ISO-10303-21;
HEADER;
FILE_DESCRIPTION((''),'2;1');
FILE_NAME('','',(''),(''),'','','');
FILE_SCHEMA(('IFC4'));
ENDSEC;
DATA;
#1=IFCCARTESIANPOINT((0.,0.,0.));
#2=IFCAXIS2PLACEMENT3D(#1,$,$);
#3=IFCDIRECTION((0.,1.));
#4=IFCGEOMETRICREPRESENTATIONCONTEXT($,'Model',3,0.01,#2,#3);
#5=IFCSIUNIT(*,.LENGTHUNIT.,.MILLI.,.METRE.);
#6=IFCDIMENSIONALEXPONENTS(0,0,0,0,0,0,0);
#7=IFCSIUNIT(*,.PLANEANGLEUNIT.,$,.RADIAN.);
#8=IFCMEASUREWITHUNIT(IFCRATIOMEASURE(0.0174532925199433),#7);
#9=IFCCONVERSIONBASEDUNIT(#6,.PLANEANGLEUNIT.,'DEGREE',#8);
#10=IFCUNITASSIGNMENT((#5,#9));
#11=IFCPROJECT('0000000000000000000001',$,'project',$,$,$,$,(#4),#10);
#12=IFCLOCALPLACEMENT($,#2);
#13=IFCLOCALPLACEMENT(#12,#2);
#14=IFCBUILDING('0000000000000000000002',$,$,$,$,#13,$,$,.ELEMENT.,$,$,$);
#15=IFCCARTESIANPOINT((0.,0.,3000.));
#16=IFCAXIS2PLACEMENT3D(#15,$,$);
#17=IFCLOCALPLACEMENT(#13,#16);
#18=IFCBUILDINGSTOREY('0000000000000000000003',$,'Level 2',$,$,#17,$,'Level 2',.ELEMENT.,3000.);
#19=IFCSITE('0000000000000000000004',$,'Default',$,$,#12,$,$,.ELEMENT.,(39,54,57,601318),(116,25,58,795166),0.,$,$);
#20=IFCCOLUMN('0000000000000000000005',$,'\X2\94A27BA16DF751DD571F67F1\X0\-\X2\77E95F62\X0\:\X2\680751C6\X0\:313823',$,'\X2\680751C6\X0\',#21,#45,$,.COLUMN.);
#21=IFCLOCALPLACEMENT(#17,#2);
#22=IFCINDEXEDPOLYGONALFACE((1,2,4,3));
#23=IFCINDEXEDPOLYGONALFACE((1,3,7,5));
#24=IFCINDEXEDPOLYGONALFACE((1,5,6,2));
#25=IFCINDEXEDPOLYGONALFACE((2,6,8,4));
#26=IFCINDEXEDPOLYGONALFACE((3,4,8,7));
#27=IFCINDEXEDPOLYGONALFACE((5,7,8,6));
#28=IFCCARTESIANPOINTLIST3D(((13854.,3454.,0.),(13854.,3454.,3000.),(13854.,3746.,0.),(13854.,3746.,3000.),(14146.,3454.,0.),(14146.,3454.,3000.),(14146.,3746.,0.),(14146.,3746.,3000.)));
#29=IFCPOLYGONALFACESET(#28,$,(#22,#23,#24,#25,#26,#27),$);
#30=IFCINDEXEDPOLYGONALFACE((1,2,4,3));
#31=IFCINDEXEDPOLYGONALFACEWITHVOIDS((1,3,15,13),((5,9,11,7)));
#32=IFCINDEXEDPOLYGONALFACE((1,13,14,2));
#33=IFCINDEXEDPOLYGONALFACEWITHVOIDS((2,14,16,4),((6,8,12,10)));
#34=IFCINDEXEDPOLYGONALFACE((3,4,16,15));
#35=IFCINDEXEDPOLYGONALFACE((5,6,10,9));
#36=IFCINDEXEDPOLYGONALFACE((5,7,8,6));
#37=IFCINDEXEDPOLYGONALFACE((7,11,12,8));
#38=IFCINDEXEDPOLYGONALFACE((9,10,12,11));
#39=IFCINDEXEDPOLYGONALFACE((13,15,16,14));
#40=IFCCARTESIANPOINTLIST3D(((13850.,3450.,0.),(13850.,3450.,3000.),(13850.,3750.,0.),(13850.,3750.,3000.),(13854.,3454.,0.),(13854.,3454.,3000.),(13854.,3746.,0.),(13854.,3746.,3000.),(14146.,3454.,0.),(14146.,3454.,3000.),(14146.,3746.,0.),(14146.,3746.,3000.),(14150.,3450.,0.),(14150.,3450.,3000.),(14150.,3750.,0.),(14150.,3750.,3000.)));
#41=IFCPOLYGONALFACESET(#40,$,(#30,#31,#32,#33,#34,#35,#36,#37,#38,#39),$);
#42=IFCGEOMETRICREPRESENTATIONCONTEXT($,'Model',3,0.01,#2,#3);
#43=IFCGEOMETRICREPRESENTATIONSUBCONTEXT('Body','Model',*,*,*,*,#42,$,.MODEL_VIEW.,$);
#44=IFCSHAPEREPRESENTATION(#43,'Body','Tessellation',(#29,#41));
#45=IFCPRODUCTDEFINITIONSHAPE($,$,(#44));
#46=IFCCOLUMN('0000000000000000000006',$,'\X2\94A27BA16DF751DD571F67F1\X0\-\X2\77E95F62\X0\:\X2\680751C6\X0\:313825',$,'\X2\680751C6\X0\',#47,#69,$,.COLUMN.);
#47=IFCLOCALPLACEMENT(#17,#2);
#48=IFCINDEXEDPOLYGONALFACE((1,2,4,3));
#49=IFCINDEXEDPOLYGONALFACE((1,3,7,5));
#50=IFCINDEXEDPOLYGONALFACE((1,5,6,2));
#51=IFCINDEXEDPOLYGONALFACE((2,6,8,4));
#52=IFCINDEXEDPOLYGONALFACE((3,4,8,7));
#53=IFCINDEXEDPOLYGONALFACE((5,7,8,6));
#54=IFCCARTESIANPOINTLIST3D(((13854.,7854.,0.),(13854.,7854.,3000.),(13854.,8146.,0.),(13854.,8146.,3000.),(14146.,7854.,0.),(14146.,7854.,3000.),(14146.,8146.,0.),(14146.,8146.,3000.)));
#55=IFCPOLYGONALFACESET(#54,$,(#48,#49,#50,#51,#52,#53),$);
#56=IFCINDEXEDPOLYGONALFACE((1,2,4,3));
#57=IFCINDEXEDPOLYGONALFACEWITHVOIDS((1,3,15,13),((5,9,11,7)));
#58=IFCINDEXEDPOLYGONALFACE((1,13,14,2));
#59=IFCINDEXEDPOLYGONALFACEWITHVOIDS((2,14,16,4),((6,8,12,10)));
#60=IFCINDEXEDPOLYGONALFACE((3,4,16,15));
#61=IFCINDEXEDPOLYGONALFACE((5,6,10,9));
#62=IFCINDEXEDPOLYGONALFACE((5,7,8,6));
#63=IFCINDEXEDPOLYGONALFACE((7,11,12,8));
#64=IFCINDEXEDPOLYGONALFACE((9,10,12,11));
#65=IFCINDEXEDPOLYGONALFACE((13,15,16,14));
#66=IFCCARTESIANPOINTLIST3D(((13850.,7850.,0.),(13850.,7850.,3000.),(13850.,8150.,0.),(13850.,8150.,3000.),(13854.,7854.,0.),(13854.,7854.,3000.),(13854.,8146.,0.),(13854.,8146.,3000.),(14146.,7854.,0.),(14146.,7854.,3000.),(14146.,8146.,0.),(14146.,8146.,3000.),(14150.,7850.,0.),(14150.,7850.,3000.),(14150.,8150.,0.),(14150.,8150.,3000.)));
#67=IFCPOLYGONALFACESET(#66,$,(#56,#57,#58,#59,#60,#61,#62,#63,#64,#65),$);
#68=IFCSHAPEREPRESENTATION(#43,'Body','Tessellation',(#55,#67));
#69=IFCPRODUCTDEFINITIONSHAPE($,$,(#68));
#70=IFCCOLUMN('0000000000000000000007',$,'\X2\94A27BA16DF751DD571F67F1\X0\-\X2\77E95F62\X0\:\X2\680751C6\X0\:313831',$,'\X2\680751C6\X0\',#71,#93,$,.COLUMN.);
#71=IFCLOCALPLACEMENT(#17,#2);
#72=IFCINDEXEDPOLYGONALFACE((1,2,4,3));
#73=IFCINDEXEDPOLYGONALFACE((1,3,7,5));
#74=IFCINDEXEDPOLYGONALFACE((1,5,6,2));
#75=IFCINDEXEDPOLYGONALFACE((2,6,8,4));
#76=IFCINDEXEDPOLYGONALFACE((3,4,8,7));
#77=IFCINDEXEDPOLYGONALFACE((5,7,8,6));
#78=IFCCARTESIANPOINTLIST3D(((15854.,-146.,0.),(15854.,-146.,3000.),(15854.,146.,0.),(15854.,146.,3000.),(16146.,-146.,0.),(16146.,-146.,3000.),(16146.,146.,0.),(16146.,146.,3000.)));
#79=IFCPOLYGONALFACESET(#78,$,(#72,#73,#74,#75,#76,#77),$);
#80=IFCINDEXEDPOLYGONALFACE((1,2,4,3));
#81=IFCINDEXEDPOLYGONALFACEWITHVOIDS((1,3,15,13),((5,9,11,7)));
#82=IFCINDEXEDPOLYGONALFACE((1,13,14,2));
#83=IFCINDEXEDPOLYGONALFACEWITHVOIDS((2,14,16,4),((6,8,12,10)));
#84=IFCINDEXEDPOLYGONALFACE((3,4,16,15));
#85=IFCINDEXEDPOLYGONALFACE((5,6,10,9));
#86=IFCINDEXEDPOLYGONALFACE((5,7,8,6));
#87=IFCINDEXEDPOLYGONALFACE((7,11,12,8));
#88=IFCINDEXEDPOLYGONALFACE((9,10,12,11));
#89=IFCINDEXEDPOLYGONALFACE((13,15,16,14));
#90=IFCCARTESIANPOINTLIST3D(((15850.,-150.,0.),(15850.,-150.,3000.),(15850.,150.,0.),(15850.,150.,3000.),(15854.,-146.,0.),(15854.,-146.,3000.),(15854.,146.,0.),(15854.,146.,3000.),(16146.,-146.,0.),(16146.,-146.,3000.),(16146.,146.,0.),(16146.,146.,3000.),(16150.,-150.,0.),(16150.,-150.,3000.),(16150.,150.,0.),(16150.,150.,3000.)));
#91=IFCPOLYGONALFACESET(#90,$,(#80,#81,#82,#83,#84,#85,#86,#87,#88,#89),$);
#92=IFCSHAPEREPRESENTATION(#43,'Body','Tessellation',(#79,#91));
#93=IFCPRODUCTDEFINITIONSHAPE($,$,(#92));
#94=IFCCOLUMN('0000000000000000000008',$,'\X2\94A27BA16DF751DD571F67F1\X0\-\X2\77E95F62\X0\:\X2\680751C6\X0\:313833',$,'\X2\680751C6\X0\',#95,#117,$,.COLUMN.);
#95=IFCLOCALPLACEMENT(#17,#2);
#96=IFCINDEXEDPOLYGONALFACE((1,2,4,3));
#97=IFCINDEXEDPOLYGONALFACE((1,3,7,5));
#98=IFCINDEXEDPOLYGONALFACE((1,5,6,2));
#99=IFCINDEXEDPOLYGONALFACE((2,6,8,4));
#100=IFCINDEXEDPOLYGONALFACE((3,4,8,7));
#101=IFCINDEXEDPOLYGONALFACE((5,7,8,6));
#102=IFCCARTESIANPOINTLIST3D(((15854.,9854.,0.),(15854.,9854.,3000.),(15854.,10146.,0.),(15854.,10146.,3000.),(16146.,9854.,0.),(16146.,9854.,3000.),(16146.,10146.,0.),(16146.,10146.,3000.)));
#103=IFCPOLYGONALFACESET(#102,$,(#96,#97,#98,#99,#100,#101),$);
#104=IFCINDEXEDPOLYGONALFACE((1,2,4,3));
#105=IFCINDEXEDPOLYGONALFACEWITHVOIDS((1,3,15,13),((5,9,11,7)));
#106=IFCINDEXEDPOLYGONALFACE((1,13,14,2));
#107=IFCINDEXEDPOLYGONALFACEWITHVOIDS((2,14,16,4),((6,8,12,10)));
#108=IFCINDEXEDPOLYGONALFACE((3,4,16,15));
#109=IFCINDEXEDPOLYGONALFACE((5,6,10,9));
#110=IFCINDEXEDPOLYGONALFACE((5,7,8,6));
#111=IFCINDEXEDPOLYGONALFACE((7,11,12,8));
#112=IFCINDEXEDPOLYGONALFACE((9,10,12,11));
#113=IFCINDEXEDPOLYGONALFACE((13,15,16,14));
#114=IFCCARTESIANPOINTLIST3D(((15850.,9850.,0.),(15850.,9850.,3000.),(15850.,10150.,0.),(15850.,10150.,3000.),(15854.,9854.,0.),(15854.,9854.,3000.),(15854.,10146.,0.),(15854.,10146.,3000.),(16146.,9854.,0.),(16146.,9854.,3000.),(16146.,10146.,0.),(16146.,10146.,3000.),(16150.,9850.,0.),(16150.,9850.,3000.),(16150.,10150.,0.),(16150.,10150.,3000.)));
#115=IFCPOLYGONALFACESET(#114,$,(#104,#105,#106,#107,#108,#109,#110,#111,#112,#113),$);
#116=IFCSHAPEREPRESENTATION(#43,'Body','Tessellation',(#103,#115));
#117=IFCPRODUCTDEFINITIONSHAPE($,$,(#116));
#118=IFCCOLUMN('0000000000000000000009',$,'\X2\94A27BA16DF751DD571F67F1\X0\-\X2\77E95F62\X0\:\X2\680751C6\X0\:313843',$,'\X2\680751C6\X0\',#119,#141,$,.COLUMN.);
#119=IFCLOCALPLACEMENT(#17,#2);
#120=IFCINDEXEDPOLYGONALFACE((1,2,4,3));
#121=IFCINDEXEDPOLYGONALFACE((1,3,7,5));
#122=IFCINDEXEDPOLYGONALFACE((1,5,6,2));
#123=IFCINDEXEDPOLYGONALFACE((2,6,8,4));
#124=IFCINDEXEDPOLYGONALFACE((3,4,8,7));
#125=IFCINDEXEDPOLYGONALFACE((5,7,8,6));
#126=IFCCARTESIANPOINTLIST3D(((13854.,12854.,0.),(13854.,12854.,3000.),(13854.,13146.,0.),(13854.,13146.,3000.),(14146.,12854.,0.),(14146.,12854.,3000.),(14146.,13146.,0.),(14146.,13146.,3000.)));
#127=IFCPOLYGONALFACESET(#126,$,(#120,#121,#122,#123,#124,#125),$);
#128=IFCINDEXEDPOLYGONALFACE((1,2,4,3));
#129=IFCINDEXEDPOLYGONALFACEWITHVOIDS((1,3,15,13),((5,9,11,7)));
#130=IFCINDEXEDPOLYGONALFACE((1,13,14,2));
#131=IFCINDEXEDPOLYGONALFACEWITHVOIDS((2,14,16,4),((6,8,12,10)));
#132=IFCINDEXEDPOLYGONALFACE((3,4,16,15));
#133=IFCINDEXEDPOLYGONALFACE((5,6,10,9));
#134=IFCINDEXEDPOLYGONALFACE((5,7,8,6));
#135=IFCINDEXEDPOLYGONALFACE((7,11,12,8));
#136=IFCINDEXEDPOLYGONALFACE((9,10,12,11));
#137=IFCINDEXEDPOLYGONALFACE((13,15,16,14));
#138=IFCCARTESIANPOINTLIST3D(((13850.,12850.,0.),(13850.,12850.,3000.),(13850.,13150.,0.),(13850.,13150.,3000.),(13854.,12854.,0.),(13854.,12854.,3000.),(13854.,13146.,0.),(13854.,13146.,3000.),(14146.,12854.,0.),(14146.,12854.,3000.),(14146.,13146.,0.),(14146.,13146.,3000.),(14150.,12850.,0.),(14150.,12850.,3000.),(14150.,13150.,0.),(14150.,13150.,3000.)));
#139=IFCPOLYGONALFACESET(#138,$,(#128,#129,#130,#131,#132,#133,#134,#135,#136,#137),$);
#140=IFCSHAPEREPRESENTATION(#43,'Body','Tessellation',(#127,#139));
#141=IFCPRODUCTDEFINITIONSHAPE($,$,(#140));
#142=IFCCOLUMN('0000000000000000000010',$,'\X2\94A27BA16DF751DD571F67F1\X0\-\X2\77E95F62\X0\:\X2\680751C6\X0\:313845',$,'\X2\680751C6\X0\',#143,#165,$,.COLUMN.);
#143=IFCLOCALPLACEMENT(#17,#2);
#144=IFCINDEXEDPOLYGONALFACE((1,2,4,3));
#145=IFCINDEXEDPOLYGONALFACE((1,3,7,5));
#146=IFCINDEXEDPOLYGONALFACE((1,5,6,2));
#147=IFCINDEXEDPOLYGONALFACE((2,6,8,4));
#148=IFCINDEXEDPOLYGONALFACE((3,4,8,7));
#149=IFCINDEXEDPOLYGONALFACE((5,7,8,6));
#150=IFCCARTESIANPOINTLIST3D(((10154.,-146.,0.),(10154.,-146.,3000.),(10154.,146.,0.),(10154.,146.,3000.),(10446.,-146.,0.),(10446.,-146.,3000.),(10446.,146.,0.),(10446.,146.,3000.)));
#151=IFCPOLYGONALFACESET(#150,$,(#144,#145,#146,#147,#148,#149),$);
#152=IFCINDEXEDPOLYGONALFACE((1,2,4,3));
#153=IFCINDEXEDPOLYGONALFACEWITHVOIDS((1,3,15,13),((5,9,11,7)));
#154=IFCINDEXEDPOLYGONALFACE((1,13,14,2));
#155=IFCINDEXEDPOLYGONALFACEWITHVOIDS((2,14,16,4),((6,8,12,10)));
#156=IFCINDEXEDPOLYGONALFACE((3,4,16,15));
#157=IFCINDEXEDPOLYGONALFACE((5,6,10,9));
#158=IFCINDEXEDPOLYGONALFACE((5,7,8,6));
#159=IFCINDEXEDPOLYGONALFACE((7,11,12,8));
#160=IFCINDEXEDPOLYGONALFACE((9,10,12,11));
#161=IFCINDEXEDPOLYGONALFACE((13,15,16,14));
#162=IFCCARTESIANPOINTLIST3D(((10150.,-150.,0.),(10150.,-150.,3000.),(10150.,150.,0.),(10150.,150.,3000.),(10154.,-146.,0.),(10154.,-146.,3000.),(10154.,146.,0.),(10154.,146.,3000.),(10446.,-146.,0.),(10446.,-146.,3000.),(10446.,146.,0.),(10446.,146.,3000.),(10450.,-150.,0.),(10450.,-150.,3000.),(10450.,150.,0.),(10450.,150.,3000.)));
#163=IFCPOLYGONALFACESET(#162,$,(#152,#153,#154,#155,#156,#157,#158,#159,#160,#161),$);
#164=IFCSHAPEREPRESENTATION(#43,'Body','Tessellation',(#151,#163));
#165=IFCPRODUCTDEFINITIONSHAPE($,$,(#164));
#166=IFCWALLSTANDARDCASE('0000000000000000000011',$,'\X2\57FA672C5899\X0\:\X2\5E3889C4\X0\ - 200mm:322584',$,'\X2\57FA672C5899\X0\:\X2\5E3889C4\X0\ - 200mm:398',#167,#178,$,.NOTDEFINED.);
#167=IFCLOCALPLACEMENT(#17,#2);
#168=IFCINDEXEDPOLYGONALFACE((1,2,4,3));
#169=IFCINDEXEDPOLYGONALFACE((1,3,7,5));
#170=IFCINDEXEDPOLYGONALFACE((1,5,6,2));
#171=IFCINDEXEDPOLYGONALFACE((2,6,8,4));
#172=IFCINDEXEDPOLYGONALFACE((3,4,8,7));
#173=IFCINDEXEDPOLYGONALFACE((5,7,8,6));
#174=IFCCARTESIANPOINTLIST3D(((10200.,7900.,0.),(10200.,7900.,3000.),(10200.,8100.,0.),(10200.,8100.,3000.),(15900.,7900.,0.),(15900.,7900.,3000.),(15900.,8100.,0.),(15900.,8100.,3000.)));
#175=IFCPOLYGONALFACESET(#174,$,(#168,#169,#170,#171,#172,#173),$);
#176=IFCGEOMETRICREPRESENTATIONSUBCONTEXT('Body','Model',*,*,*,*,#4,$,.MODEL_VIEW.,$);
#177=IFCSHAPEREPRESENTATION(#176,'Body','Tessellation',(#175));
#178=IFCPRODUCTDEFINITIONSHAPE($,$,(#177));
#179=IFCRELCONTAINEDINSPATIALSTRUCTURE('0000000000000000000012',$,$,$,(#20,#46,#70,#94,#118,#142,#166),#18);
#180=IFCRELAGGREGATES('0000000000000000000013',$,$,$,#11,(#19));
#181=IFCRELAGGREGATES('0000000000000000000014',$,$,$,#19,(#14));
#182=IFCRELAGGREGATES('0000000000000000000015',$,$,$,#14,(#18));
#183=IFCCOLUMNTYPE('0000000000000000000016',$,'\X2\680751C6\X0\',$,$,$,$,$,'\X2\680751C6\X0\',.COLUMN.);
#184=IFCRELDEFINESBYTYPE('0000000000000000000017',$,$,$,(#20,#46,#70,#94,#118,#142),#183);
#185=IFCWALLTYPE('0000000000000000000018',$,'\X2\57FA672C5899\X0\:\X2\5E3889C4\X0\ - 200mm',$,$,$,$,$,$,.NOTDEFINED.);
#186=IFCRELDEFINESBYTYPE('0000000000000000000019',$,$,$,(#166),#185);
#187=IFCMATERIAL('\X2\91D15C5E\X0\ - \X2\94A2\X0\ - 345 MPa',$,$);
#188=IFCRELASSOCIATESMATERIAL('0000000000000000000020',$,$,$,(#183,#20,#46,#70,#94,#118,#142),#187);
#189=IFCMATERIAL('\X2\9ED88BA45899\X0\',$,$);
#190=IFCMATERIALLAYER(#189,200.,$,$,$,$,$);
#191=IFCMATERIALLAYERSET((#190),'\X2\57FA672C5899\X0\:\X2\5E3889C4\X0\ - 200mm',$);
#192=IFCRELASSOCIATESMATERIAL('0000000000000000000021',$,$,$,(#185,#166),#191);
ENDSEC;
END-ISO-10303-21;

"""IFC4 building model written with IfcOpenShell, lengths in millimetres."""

from ifc_helpers import new_model, entity, si_unit, converted_unit, direction, frame, frame_2d, origin, origin_2d_with_axis, place, context, subcontext, project, spatial, polyline, rectangle, outline, extrude, source, transform, mapped, material, layer, layer_set, layer_usage, type_object, type_shapes, element, save


model = new_model("IFC4")

# Units and contexts
model_context_1 = context("Model", 3, precision=0.01, world=origin(), true_north=direction((0.0, 1.0)))
model_context_2 = context("Model", 3, precision=0.01, world=origin(), true_north=direction((0.0, 1.0)))
body_context_1 = subcontext(model_context_1, "Body", "Model", "MODEL_VIEW")
body_context_2 = subcontext(model_context_2, "Body", "Model", "MODEL_VIEW")
ifc_project = project(units=[si_unit("LENGTHUNIT", "METRE", prefix="MILLI"), converted_unit("PLANEANGLEUNIT", "DEGREE", entity("IfcRatioMeasure", 0.0174532925199433), si_unit("PLANEANGLEUNIT", "RADIAN"), dimensions=[0, 0, 0, 0, 0, 0, 0])], contexts=[model_context_1])

# Site, building, storey
site_placement = place(None, origin())
site = spatial("IfcSite", under=ifc_project, at=site_placement, Name="Default", CompositionType="ELEMENT", RefLatitude=(39, 54, 57, 601318), RefLongitude=(116, 25, 58, 795166), RefElevation=0.0)
building_placement = place(site_placement, origin())
building = spatial("IfcBuilding", under=site, at=building_placement, CompositionType="ELEMENT")
storey_placement = place(building_placement, frame((0.0, 0.0, 3000.0)))
storey = spatial("IfcBuildingStorey", under=building, at=storey_placement, Name="Level 2", LongName="Level 2", CompositionType="ELEMENT", Elevation=3000.0)

# Columns
ifc_material_1 = material(Name="金属 - 钢 - 345 MPa")
column_type = type_object("IfcColumnType", Name="标准", ElementType="标准", PredefinedType="COLUMN", material=ifc_material_1)
shared_shape_1 = source(origin(), body_context_2, "Body", "SweptSolid", [
    extrude(rectangle(XDim=292.0, YDim=292.0, at=origin_2d_with_axis()), frame((150.0, 150.0, 0.0), z_axis=(0.0, 0.0, 1.0), x_axis=(-1.0, 0.0, 0.0)), (0.0, 0.0, 1.0), 3000.0),
    extrude(outline(polyline([(-150.0, -150.0), (150.0, -150.0), (150.0, 150.0), (-150.0, 150.0), (-150.0, -150.0)]), holes=[polyline([(-146.0, -146.0), (-146.0, 146.0), (146.0, 146.0), (146.0, -146.0), (-146.0, -146.0)])]), frame((150.0, 150.0, 0.0), z_axis=(0.0, 0.0, 1.0), x_axis=(-1.0, 0.0, 0.0)), (0.0, 0.0, 1.0), 3000.0),
])
type_shapes(column_type, [shared_shape_1])
placement_1 = place(None, origin())
placement_2 = place(placement_1, origin())
placement_3 = place(placement_2, frame((0.0, 0.0, 3000.0)))
for number, where, name in (
    (1, (13850.0, 3450.0, 0.0), "钢管混凝土柱-矩形:标准:313823"),
    (2, (13850.0, 7850.0, 0.0), "钢管混凝土柱-矩形:标准:313825"),
    (3, (15850.0, -150.0, 0.0), "钢管混凝土柱-矩形:标准:313831"),
    (4, (15850.0, 9850.0, 0.0), "钢管混凝土柱-矩形:标准:313833"),
    (5, (13850.0, 12850.0, 0.0), "钢管混凝土柱-矩形:标准:313843"),
    (6, (10150.0, -150.0, 0.0), "钢管混凝土柱-矩形:标准:313845"),
):
    element("IfcColumn", number, at=place(placement_3, frame(where)), inside=storey, type_object=column_type, material=ifc_material_1, Name=name, ObjectType="标准", PredefinedType="COLUMN", context=body_context_2, shape_type="MappedRepresentation", body=[
        mapped(shared_shape_1, transform((0.0, 0.0, 0.0), scale=1.0)),
    ])

# Wall
ifc_material_2 = material(Name="默认墙")
ifc_layer = layer(ifc_material_2, 200.0)
ifc_layer_set = layer_set([ifc_layer], Name="基本墙:常规 - 200mm")
ifc_layer_usage_1 = layer_usage(ifc_layer_set, "AXIS2", "NEGATIVE", 100.0)
wall_type = type_object("IfcWallType", Name="基本墙:常规 - 200mm", PredefinedType="NOTDEFINED", material=ifc_layer_set)
wall_1_placement = place(storey_placement, frame((10200.0, 8000.0, 0.0)))
element("IfcWallStandardCase", 7, at=wall_1_placement, inside=storey, type_object=wall_type, material=ifc_layer_usage_1, Name="基本墙:常规 - 200mm:322584", ObjectType="基本墙:常规 - 200mm:398", PredefinedType="NOTDEFINED", context=body_context_1, shape_type="SweptSolid", body=[
    extrude(rectangle(XDim=5700.0, YDim=200.0, at=frame_2d((2850.0, 0.0), x_axis=(-1.0, 0.0))), origin(), (0.0, 0.0, 1.0), 3000.0),
])

save(model, "model.ifc")
